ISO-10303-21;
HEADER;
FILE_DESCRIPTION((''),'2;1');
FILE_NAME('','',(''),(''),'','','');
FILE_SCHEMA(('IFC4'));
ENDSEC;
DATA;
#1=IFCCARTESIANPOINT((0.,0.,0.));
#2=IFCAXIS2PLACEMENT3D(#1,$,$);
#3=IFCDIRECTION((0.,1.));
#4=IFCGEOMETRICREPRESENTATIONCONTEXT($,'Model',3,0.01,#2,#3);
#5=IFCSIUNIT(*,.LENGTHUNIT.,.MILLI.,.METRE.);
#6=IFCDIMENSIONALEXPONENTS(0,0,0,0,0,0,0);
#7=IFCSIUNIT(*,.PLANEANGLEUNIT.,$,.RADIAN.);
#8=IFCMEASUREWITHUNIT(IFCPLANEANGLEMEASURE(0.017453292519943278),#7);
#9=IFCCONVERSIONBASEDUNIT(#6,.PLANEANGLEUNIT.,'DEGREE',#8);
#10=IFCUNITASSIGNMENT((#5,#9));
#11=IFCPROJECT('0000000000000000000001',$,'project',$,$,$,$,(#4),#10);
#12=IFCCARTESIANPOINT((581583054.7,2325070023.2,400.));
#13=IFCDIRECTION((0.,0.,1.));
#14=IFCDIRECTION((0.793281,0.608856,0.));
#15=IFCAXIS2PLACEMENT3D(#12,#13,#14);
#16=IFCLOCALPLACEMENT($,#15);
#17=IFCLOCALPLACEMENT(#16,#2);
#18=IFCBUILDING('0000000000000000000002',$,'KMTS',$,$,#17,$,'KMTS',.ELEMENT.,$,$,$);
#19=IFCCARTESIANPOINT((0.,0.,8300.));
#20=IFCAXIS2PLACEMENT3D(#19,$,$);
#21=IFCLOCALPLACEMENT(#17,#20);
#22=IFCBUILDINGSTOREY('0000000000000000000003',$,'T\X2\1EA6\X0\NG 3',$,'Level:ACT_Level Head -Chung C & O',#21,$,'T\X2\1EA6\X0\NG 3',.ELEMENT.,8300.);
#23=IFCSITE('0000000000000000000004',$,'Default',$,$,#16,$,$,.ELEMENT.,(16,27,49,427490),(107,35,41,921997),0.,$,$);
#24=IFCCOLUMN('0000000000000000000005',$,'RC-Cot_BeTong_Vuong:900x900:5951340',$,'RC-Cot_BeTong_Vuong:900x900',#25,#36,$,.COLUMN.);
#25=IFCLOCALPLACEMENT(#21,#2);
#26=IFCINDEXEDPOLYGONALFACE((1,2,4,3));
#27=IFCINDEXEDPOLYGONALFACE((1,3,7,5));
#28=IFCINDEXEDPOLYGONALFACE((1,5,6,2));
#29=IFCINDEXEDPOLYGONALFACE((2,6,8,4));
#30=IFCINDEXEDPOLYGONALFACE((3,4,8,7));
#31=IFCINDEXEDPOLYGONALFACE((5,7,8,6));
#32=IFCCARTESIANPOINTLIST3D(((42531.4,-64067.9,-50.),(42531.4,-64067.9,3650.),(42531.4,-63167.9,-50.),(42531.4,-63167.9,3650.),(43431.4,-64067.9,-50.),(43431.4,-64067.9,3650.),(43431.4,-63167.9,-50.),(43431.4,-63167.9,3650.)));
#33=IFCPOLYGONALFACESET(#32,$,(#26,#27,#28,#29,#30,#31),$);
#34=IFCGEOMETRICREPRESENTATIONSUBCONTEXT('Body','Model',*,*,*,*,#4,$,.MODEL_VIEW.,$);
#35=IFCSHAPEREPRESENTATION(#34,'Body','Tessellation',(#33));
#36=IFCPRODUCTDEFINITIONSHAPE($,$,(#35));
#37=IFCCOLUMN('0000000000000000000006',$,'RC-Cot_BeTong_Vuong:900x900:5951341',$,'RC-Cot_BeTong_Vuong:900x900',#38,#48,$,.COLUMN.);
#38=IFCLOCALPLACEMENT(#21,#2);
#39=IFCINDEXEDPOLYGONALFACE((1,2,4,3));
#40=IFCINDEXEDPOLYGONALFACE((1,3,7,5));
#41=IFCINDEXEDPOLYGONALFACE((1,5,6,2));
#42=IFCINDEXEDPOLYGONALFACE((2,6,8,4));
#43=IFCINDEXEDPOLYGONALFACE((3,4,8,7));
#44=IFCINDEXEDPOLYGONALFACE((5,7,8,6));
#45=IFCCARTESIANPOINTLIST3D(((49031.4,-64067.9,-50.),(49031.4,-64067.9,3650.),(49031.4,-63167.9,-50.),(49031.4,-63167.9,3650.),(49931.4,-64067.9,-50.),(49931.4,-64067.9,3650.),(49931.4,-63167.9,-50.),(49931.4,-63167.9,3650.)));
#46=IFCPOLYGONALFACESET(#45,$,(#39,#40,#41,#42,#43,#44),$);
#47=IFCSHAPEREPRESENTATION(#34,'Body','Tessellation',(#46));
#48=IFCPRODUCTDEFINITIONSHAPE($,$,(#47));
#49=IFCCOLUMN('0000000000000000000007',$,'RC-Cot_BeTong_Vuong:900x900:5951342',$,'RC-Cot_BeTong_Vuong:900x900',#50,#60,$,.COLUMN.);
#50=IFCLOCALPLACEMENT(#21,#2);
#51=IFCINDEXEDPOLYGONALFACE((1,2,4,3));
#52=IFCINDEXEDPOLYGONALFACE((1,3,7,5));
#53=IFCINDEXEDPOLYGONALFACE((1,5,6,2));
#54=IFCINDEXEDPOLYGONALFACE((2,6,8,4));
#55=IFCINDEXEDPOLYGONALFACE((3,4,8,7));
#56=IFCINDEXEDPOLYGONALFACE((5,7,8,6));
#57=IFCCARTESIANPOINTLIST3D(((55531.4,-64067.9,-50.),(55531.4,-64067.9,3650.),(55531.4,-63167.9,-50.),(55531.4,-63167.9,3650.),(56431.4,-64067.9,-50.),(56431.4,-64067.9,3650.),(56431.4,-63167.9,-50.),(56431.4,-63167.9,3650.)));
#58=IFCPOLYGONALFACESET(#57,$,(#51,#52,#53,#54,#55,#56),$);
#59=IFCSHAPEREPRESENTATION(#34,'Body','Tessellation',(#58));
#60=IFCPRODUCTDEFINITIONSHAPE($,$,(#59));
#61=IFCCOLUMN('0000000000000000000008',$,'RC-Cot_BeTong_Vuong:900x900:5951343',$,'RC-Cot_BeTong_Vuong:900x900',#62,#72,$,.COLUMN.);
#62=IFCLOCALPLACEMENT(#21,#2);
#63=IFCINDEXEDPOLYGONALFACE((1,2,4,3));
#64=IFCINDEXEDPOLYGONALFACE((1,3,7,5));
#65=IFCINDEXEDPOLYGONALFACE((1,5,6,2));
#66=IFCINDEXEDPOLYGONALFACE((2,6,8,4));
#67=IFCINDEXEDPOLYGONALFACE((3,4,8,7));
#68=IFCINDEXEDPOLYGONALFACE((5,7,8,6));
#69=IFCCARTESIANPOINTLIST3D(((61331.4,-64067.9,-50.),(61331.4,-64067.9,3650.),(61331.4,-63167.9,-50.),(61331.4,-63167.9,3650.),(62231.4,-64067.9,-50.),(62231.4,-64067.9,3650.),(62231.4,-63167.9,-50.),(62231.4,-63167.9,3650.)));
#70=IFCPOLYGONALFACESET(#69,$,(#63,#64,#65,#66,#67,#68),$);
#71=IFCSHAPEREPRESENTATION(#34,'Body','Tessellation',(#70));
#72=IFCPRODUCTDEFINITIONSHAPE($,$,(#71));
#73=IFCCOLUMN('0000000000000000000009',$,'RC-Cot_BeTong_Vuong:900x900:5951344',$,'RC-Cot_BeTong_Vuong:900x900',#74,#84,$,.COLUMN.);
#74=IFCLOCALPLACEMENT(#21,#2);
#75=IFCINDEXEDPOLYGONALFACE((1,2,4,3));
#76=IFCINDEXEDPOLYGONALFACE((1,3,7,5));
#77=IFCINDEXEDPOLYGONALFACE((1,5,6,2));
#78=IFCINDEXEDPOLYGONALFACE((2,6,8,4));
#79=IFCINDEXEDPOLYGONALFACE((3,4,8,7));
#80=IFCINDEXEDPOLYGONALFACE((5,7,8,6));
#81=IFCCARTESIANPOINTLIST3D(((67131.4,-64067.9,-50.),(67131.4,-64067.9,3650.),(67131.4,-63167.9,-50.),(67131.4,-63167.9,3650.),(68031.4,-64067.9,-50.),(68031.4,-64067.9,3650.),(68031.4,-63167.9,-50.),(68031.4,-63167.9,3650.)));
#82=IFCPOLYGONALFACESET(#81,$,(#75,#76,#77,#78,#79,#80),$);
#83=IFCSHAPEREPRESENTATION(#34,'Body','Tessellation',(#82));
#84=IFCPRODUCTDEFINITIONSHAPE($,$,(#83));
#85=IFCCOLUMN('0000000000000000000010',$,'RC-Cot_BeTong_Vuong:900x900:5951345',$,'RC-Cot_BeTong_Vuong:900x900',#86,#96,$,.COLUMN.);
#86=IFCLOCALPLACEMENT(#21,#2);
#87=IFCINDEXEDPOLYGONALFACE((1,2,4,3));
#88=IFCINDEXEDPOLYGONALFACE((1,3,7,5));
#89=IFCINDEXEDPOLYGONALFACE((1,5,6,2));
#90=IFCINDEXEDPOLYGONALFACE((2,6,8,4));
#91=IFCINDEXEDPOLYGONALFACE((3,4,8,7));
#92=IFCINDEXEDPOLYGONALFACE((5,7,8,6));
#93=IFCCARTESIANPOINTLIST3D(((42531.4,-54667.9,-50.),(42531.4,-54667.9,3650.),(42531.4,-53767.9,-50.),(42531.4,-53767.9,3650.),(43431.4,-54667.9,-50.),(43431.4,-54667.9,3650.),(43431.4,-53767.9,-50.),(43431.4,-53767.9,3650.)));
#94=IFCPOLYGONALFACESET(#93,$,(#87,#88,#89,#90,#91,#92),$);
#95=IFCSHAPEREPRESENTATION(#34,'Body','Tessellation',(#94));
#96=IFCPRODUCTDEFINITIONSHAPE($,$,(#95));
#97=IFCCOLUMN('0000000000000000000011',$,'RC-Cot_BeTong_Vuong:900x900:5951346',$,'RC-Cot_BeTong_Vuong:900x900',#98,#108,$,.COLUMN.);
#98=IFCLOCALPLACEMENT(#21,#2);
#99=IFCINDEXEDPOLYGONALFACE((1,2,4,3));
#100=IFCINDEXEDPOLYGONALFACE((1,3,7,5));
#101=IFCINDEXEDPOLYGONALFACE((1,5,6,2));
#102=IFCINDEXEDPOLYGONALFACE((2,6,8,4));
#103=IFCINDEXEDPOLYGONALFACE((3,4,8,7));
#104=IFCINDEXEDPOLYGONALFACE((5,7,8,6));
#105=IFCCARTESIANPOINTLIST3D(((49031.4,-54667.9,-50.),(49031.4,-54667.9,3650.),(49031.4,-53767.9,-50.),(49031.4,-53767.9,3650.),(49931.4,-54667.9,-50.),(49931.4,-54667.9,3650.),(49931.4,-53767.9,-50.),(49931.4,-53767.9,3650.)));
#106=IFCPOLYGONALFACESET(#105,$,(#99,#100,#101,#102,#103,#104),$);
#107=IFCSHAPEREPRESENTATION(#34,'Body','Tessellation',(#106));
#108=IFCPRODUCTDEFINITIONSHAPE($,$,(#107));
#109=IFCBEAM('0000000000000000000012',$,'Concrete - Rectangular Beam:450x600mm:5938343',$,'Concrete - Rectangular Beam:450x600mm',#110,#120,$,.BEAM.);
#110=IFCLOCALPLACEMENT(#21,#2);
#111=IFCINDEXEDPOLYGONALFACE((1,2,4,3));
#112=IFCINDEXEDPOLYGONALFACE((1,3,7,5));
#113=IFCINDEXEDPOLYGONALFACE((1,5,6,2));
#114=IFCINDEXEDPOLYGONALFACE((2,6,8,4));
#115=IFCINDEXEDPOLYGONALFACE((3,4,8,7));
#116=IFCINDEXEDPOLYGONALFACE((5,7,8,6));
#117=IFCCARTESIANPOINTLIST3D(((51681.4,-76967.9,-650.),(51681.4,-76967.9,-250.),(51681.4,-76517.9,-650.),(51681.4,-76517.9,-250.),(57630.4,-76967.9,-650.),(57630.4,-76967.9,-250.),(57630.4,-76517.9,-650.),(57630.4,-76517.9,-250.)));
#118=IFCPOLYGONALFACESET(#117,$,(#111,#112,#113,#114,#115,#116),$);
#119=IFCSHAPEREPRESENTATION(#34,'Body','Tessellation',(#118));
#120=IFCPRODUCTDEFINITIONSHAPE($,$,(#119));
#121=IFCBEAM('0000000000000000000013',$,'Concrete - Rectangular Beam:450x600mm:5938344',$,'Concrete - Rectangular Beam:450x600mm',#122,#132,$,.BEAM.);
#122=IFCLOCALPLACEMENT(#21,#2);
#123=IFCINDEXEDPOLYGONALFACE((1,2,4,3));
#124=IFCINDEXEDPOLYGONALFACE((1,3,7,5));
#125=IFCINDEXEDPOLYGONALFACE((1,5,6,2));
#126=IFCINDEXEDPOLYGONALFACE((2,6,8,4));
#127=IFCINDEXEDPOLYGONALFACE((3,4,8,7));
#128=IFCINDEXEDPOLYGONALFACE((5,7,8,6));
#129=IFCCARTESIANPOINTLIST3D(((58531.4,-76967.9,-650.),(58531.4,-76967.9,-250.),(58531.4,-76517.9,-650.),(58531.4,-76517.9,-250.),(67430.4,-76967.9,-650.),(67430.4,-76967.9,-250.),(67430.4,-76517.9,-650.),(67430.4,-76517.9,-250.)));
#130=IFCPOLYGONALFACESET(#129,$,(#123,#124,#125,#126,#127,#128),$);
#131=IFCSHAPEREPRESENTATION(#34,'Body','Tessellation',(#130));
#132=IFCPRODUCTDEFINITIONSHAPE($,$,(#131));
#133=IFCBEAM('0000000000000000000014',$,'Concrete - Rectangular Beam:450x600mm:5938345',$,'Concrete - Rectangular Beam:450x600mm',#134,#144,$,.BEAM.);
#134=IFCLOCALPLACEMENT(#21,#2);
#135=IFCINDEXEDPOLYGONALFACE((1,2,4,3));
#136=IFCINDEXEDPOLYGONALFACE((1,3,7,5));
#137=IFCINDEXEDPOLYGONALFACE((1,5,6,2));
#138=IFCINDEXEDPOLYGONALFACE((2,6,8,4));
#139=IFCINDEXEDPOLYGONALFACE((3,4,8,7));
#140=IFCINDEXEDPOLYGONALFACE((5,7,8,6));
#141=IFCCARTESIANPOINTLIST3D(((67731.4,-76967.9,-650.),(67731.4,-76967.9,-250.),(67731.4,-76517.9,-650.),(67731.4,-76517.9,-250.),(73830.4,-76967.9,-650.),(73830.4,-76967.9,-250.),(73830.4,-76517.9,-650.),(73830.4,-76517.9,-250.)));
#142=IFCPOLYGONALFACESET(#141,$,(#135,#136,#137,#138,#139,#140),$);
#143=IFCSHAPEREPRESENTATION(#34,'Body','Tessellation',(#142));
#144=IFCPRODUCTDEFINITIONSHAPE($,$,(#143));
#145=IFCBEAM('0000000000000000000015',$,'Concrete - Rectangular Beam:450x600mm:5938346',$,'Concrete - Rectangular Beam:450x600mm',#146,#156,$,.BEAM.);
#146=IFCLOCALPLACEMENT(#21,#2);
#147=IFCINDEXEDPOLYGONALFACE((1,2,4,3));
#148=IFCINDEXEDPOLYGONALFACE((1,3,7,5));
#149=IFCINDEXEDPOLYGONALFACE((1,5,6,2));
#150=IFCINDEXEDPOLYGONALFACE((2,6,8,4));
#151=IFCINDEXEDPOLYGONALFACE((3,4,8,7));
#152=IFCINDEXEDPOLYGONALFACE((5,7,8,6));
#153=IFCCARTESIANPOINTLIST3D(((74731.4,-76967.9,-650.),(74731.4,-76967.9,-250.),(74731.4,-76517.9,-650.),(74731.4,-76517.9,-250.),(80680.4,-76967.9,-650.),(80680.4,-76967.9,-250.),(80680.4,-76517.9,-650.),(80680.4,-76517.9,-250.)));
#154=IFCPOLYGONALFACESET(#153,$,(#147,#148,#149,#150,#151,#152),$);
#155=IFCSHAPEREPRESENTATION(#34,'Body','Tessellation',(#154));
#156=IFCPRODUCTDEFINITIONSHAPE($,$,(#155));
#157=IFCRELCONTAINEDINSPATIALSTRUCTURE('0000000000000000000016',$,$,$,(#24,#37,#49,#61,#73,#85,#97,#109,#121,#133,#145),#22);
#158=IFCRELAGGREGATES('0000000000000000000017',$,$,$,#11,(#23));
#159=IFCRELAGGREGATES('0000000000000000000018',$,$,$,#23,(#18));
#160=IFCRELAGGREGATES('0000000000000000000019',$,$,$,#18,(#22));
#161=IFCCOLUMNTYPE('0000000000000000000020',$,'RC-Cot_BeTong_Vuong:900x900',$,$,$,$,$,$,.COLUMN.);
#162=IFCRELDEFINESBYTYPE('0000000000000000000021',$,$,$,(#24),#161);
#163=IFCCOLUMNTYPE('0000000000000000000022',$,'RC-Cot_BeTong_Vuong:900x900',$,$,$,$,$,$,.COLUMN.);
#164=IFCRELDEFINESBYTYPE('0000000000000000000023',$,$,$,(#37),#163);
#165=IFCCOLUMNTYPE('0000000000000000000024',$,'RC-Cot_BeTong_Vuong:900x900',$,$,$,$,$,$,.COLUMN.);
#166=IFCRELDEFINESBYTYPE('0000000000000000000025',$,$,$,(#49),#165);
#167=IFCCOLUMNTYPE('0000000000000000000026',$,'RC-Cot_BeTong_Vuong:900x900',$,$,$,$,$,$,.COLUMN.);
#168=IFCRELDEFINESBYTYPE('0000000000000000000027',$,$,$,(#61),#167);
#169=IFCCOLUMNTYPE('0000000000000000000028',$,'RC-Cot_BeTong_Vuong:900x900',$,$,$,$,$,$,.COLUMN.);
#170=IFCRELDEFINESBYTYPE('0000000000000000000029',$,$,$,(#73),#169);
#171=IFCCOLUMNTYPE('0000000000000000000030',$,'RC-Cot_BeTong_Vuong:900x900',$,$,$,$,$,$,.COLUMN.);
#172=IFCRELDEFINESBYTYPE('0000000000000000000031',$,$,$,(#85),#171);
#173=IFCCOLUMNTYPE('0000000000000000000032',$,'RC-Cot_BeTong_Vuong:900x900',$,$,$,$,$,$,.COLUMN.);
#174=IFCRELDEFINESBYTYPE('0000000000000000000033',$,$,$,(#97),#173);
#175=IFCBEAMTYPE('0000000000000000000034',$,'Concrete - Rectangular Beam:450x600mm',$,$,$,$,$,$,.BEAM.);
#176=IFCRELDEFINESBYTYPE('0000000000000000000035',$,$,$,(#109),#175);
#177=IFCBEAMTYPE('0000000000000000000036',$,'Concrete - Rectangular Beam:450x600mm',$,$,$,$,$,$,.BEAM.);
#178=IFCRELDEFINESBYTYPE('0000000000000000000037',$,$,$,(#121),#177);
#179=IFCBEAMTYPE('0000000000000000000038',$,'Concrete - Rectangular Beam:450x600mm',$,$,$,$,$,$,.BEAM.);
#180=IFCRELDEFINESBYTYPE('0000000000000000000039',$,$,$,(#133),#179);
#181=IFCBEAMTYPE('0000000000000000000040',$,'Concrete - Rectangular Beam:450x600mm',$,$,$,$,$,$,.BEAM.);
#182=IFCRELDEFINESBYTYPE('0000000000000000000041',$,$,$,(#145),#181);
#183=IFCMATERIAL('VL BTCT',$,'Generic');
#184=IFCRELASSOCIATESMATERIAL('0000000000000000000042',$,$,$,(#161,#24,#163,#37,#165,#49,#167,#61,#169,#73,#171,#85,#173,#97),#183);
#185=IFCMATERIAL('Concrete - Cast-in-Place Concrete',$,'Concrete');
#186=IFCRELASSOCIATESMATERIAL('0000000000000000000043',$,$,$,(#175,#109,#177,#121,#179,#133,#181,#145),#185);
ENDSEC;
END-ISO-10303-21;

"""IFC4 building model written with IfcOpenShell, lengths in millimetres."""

from ifc_helpers import new_model, entity, si_unit, converted_unit, direction, frame, origin, place, context, subcontext, project, spatial, indexed_curve, outline, extrude, source, transform, mapped, material, type_object, type_shapes, element, save


model = new_model("IFC4")

# Units and contexts
model_context = context("Model", 3, precision=0.01, world=origin(), true_north=direction((0.0, 1.0)))
body_context = subcontext(model_context, "Body", "Model", "MODEL_VIEW")
ifc_project = project(units=[si_unit("LENGTHUNIT", "METRE", prefix="MILLI"), converted_unit("PLANEANGLEUNIT", "DEGREE", entity("IfcPlaneAngleMeasure", 0.017453292519943278), si_unit("PLANEANGLEUNIT", "RADIAN"), dimensions=[0, 0, 0, 0, 0, 0, 0])], contexts=[model_context])

# Site, building, storey
site_placement = place(None, frame((581583054.7, 2325070023.2, 400.0), z_axis=(0.0, 0.0, 1.0), x_axis=(0.793281, 0.608856, 0.0)))
site = spatial("IfcSite", under=ifc_project, at=site_placement, Name="Default", CompositionType="ELEMENT", RefLatitude=(16, 27, 49, 427490), RefLongitude=(107, 35, 41, 921997), RefElevation=0.0)
building_placement = place(site_placement, origin())
building = spatial("IfcBuilding", under=site, at=building_placement, Name="KMTS", LongName="KMTS", CompositionType="ELEMENT")
storey_placement = place(building_placement, frame((0.0, 0.0, 8300.0)))
storey = spatial("IfcBuildingStorey", under=building, at=storey_placement, Name="TẦNG 3", ObjectType="Level:ACT_Level Head -Chung C & O", LongName="TẦNG 3", CompositionType="ELEMENT", Elevation=8300.0)

# Columns
ifc_material_1 = material(Name="VL BTCT", Category="Generic")
column_type_1 = type_object("IfcColumnType", Name="RC-Cot_BeTong_Vuong:900x900", PredefinedType="COLUMN", material=ifc_material_1)
shared_shape_1 = source(origin(), body_context, "Body", "SweptSolid", [
    extrude(outline(indexed_curve([(-450.0, -450.0), (450.0, -450.0), (450.0, 450.0), (-450.0, 450.0), (-450.0, -450.0)], self_intersect=False)), frame((42981.4, -63617.9, 8250.0), z_axis=(0.0, 0.0, 1.0), x_axis=(-1.0, 0.0, 0.0)), (0.0, 0.0, 1.0), 3700.0),
])
type_shapes(column_type_1, [shared_shape_1])
column_1_placement = place(storey_placement, frame((0.0, 0.0, -8300.0)))
element("IfcColumn", 1, at=column_1_placement, inside=storey, type_object=column_type_1, material=ifc_material_1, Name="RC-Cot_BeTong_Vuong:900x900:5951340", ObjectType="RC-Cot_BeTong_Vuong:900x900", PredefinedType="COLUMN", context=body_context, shape_type="MappedRepresentation", body=[
    mapped(shared_shape_1, transform((0.0, 0.0, 0.0), scale=1.0)),
])
column_type_2 = type_object("IfcColumnType", Name="RC-Cot_BeTong_Vuong:900x900", PredefinedType="COLUMN", material=ifc_material_1)
shared_shape_2 = source(origin(), body_context, "Body", "SweptSolid", [
    extrude(outline(indexed_curve([(-450.0, -450.0), (450.0, -450.0), (450.0, 450.0), (-450.0, 450.0), (-450.0, -450.0)], self_intersect=False)), frame((49481.4, -63617.9, 8250.0), z_axis=(0.0, 0.0, 1.0), x_axis=(-1.0, 0.0, 0.0)), (0.0, 0.0, 1.0), 3700.0),
])
type_shapes(column_type_2, [shared_shape_2])
column_2_placement = place(storey_placement, frame((0.0, 0.0, -8300.0)))
element("IfcColumn", 2, at=column_2_placement, inside=storey, type_object=column_type_2, material=ifc_material_1, Name="RC-Cot_BeTong_Vuong:900x900:5951341", ObjectType="RC-Cot_BeTong_Vuong:900x900", PredefinedType="COLUMN", context=body_context, shape_type="MappedRepresentation", body=[
    mapped(shared_shape_2, transform((0.0, 0.0, 0.0), scale=1.0)),
])
column_type_3 = type_object("IfcColumnType", Name="RC-Cot_BeTong_Vuong:900x900", PredefinedType="COLUMN", material=ifc_material_1)
shared_shape_3 = source(origin(), body_context, "Body", "SweptSolid", [
    extrude(outline(indexed_curve([(-450.0, -450.0), (450.0, -450.0), (450.0, 450.0), (-450.0, 450.0), (-450.0, -450.0)], self_intersect=False)), frame((55981.4, -63617.9, 8250.0), z_axis=(0.0, 0.0, 1.0), x_axis=(-1.0, 0.0, 0.0)), (0.0, 0.0, 1.0), 3700.0),
])
type_shapes(column_type_3, [shared_shape_3])
column_3_placement = place(storey_placement, frame((0.0, 0.0, -8300.0)))
element("IfcColumn", 3, at=column_3_placement, inside=storey, type_object=column_type_3, material=ifc_material_1, Name="RC-Cot_BeTong_Vuong:900x900:5951342", ObjectType="RC-Cot_BeTong_Vuong:900x900", PredefinedType="COLUMN", context=body_context, shape_type="MappedRepresentation", body=[
    mapped(shared_shape_3, transform((0.0, 0.0, 0.0), scale=1.0)),
])
column_type_4 = type_object("IfcColumnType", Name="RC-Cot_BeTong_Vuong:900x900", PredefinedType="COLUMN", material=ifc_material_1)
shared_shape_4 = source(origin(), body_context, "Body", "SweptSolid", [
    extrude(outline(indexed_curve([(-450.0, -450.0), (450.0, -450.0), (450.0, 450.0), (-450.0, 450.0), (-450.0, -450.0)], self_intersect=False)), frame((61781.4, -63617.9, 8250.0), z_axis=(0.0, 0.0, 1.0), x_axis=(-1.0, 0.0, 0.0)), (0.0, 0.0, 1.0), 3700.0),
])
type_shapes(column_type_4, [shared_shape_4])
column_4_placement = place(storey_placement, frame((0.0, 0.0, -8300.0)))
element("IfcColumn", 4, at=column_4_placement, inside=storey, type_object=column_type_4, material=ifc_material_1, Name="RC-Cot_BeTong_Vuong:900x900:5951343", ObjectType="RC-Cot_BeTong_Vuong:900x900", PredefinedType="COLUMN", context=body_context, shape_type="MappedRepresentation", body=[
    mapped(shared_shape_4, transform((0.0, 0.0, 0.0), scale=1.0)),
])
column_type_5 = type_object("IfcColumnType", Name="RC-Cot_BeTong_Vuong:900x900", PredefinedType="COLUMN", material=ifc_material_1)
shared_shape_5 = source(origin(), body_context, "Body", "SweptSolid", [
    extrude(outline(indexed_curve([(-450.0, -450.0), (450.0, -450.0), (450.0, 450.0), (-450.0, 450.0), (-450.0, -450.0)], self_intersect=False)), frame((67581.4, -63617.9, 8250.0), z_axis=(0.0, 0.0, 1.0), x_axis=(-1.0, 0.0, 0.0)), (0.0, 0.0, 1.0), 3700.0),
])
type_shapes(column_type_5, [shared_shape_5])
column_5_placement = place(storey_placement, frame((0.0, 0.0, -8300.0)))
element("IfcColumn", 5, at=column_5_placement, inside=storey, type_object=column_type_5, material=ifc_material_1, Name="RC-Cot_BeTong_Vuong:900x900:5951344", ObjectType="RC-Cot_BeTong_Vuong:900x900", PredefinedType="COLUMN", context=body_context, shape_type="MappedRepresentation", body=[
    mapped(shared_shape_5, transform((0.0, 0.0, 0.0), scale=1.0)),
])
column_type_6 = type_object("IfcColumnType", Name="RC-Cot_BeTong_Vuong:900x900", PredefinedType="COLUMN", material=ifc_material_1)
shared_shape_6 = source(origin(), body_context, "Body", "SweptSolid", [
    extrude(outline(indexed_curve([(-450.0, -450.0), (450.0, -450.0), (450.0, 450.0), (-450.0, 450.0), (-450.0, -450.0)], self_intersect=False)), frame((42981.4, -54217.9, 8250.0), z_axis=(0.0, 0.0, 1.0), x_axis=(-1.0, 0.0, 0.0)), (0.0, 0.0, 1.0), 3700.0),
])
type_shapes(column_type_6, [shared_shape_6])
column_6_placement = place(storey_placement, frame((0.0, 0.0, -8300.0)))
element("IfcColumn", 6, at=column_6_placement, inside=storey, type_object=column_type_6, material=ifc_material_1, Name="RC-Cot_BeTong_Vuong:900x900:5951345", ObjectType="RC-Cot_BeTong_Vuong:900x900", PredefinedType="COLUMN", context=body_context, shape_type="MappedRepresentation", body=[
    mapped(shared_shape_6, transform((0.0, 0.0, 0.0), scale=1.0)),
])
column_type_7 = type_object("IfcColumnType", Name="RC-Cot_BeTong_Vuong:900x900", PredefinedType="COLUMN", material=ifc_material_1)
shared_shape_7 = source(origin(), body_context, "Body", "SweptSolid", [
    extrude(outline(indexed_curve([(-450.0, -450.0), (450.0, -450.0), (450.0, 450.0), (-450.0, 450.0), (-450.0, -450.0)], self_intersect=False)), frame((49481.4, -54217.9, 8250.0), z_axis=(0.0, 0.0, 1.0), x_axis=(-1.0, 0.0, 0.0)), (0.0, 0.0, 1.0), 3700.0),
])
type_shapes(column_type_7, [shared_shape_7])
column_7_placement = place(storey_placement, frame((0.0, 0.0, -8300.0)))
element("IfcColumn", 7, at=column_7_placement, inside=storey, type_object=column_type_7, material=ifc_material_1, Name="RC-Cot_BeTong_Vuong:900x900:5951346", ObjectType="RC-Cot_BeTong_Vuong:900x900", PredefinedType="COLUMN", context=body_context, shape_type="MappedRepresentation", body=[
    mapped(shared_shape_7, transform((0.0, 0.0, 0.0), scale=1.0)),
])

# Beams
ifc_material_2 = material(Name="Concrete - Cast-in-Place Concrete", Category="Concrete")
beam_type_1 = type_object("IfcBeamType", Name="Concrete - Rectangular Beam:450x600mm", PredefinedType="BEAM", material=ifc_material_2)
shared_shape_8 = source(origin(), body_context, "Body", "SweptSolid", [
    extrude(outline(indexed_curve([(-200.0, -225.0), (200.0, -225.0), (200.0, 225.0), (-200.0, 225.0), (-200.0, -225.0)], self_intersect=False)), frame((51681.4, -76742.9, 7850.0), z_axis=(1.0, 0.0, 0.0), x_axis=(0.0, 0.0, -1.0)), (0.0, 0.0, 1.0), 5949.0),
])
type_shapes(beam_type_1, [shared_shape_8])
beam_1_placement = place(storey_placement, frame((0.0, 0.0, -8300.0)))
element("IfcBeam", 8, at=beam_1_placement, inside=storey, type_object=beam_type_1, material=ifc_material_2, Name="Concrete - Rectangular Beam:450x600mm:5938343", ObjectType="Concrete - Rectangular Beam:450x600mm", PredefinedType="BEAM", context=body_context, shape_type="MappedRepresentation", body=[
    mapped(shared_shape_8, transform((0.0, 0.0, 0.0), scale=1.0)),
])
beam_type_2 = type_object("IfcBeamType", Name="Concrete - Rectangular Beam:450x600mm", PredefinedType="BEAM", material=ifc_material_2)
shared_shape_9 = source(origin(), body_context, "Body", "SweptSolid", [
    extrude(outline(indexed_curve([(-200.0, -225.0), (200.0, -225.0), (200.0, 225.0), (-200.0, 225.0), (-200.0, -225.0)], self_intersect=False)), frame((67430.4, -76742.9, 7850.0), z_axis=(-1.0, 0.0, 0.0), x_axis=(0.0, 0.0, -1.0)), (0.0, 0.0, 1.0), 8899.0),
])
type_shapes(beam_type_2, [shared_shape_9])
beam_2_placement = place(storey_placement, frame((0.0, 0.0, -8300.0)))
element("IfcBeam", 9, at=beam_2_placement, inside=storey, type_object=beam_type_2, material=ifc_material_2, Name="Concrete - Rectangular Beam:450x600mm:5938344", ObjectType="Concrete - Rectangular Beam:450x600mm", PredefinedType="BEAM", context=body_context, shape_type="MappedRepresentation", body=[
    mapped(shared_shape_9, transform((0.0, 0.0, 0.0), scale=1.0)),
])
beam_type_3 = type_object("IfcBeamType", Name="Concrete - Rectangular Beam:450x600mm", PredefinedType="BEAM", material=ifc_material_2)
shared_shape_10 = source(origin(), body_context, "Body", "SweptSolid", [
    extrude(outline(indexed_curve([(-200.0, -225.0), (200.0, -225.0), (200.0, 225.0), (-200.0, 225.0), (-200.0, -225.0)], self_intersect=False)), frame((67731.4, -76742.9, 7850.0), z_axis=(1.0, 0.0, 0.0), x_axis=(0.0, 0.0, -1.0)), (0.0, 0.0, 1.0), 6099.0),
])
type_shapes(beam_type_3, [shared_shape_10])
beam_3_placement = place(storey_placement, frame((0.0, 0.0, -8300.0)))
element("IfcBeam", 10, at=beam_3_placement, inside=storey, type_object=beam_type_3, material=ifc_material_2, Name="Concrete - Rectangular Beam:450x600mm:5938345", ObjectType="Concrete - Rectangular Beam:450x600mm", PredefinedType="BEAM", context=body_context, shape_type="MappedRepresentation", body=[
    mapped(shared_shape_10, transform((0.0, 0.0, 0.0), scale=1.0)),
])
beam_type_4 = type_object("IfcBeamType", Name="Concrete - Rectangular Beam:450x600mm", PredefinedType="BEAM", material=ifc_material_2)
shared_shape_11 = source(origin(), body_context, "Body", "SweptSolid", [
    extrude(outline(indexed_curve([(-200.0, -225.0), (200.0, -225.0), (200.0, 225.0), (-200.0, 225.0), (-200.0, -225.0)], self_intersect=False)), frame((74731.4, -76742.9, 7850.0), z_axis=(1.0, 0.0, 0.0), x_axis=(0.0, 0.0, -1.0)), (0.0, 0.0, 1.0), 5949.0),
])
type_shapes(beam_type_4, [shared_shape_11])
beam_4_placement = place(storey_placement, frame((0.0, 0.0, -8300.0)))
element("IfcBeam", 11, at=beam_4_placement, inside=storey, type_object=beam_type_4, material=ifc_material_2, Name="Concrete - Rectangular Beam:450x600mm:5938346", ObjectType="Concrete - Rectangular Beam:450x600mm", PredefinedType="BEAM", context=body_context, shape_type="MappedRepresentation", body=[
    mapped(shared_shape_11, transform((0.0, 0.0, 0.0), scale=1.0)),
])

save(model, "model.ifc")
